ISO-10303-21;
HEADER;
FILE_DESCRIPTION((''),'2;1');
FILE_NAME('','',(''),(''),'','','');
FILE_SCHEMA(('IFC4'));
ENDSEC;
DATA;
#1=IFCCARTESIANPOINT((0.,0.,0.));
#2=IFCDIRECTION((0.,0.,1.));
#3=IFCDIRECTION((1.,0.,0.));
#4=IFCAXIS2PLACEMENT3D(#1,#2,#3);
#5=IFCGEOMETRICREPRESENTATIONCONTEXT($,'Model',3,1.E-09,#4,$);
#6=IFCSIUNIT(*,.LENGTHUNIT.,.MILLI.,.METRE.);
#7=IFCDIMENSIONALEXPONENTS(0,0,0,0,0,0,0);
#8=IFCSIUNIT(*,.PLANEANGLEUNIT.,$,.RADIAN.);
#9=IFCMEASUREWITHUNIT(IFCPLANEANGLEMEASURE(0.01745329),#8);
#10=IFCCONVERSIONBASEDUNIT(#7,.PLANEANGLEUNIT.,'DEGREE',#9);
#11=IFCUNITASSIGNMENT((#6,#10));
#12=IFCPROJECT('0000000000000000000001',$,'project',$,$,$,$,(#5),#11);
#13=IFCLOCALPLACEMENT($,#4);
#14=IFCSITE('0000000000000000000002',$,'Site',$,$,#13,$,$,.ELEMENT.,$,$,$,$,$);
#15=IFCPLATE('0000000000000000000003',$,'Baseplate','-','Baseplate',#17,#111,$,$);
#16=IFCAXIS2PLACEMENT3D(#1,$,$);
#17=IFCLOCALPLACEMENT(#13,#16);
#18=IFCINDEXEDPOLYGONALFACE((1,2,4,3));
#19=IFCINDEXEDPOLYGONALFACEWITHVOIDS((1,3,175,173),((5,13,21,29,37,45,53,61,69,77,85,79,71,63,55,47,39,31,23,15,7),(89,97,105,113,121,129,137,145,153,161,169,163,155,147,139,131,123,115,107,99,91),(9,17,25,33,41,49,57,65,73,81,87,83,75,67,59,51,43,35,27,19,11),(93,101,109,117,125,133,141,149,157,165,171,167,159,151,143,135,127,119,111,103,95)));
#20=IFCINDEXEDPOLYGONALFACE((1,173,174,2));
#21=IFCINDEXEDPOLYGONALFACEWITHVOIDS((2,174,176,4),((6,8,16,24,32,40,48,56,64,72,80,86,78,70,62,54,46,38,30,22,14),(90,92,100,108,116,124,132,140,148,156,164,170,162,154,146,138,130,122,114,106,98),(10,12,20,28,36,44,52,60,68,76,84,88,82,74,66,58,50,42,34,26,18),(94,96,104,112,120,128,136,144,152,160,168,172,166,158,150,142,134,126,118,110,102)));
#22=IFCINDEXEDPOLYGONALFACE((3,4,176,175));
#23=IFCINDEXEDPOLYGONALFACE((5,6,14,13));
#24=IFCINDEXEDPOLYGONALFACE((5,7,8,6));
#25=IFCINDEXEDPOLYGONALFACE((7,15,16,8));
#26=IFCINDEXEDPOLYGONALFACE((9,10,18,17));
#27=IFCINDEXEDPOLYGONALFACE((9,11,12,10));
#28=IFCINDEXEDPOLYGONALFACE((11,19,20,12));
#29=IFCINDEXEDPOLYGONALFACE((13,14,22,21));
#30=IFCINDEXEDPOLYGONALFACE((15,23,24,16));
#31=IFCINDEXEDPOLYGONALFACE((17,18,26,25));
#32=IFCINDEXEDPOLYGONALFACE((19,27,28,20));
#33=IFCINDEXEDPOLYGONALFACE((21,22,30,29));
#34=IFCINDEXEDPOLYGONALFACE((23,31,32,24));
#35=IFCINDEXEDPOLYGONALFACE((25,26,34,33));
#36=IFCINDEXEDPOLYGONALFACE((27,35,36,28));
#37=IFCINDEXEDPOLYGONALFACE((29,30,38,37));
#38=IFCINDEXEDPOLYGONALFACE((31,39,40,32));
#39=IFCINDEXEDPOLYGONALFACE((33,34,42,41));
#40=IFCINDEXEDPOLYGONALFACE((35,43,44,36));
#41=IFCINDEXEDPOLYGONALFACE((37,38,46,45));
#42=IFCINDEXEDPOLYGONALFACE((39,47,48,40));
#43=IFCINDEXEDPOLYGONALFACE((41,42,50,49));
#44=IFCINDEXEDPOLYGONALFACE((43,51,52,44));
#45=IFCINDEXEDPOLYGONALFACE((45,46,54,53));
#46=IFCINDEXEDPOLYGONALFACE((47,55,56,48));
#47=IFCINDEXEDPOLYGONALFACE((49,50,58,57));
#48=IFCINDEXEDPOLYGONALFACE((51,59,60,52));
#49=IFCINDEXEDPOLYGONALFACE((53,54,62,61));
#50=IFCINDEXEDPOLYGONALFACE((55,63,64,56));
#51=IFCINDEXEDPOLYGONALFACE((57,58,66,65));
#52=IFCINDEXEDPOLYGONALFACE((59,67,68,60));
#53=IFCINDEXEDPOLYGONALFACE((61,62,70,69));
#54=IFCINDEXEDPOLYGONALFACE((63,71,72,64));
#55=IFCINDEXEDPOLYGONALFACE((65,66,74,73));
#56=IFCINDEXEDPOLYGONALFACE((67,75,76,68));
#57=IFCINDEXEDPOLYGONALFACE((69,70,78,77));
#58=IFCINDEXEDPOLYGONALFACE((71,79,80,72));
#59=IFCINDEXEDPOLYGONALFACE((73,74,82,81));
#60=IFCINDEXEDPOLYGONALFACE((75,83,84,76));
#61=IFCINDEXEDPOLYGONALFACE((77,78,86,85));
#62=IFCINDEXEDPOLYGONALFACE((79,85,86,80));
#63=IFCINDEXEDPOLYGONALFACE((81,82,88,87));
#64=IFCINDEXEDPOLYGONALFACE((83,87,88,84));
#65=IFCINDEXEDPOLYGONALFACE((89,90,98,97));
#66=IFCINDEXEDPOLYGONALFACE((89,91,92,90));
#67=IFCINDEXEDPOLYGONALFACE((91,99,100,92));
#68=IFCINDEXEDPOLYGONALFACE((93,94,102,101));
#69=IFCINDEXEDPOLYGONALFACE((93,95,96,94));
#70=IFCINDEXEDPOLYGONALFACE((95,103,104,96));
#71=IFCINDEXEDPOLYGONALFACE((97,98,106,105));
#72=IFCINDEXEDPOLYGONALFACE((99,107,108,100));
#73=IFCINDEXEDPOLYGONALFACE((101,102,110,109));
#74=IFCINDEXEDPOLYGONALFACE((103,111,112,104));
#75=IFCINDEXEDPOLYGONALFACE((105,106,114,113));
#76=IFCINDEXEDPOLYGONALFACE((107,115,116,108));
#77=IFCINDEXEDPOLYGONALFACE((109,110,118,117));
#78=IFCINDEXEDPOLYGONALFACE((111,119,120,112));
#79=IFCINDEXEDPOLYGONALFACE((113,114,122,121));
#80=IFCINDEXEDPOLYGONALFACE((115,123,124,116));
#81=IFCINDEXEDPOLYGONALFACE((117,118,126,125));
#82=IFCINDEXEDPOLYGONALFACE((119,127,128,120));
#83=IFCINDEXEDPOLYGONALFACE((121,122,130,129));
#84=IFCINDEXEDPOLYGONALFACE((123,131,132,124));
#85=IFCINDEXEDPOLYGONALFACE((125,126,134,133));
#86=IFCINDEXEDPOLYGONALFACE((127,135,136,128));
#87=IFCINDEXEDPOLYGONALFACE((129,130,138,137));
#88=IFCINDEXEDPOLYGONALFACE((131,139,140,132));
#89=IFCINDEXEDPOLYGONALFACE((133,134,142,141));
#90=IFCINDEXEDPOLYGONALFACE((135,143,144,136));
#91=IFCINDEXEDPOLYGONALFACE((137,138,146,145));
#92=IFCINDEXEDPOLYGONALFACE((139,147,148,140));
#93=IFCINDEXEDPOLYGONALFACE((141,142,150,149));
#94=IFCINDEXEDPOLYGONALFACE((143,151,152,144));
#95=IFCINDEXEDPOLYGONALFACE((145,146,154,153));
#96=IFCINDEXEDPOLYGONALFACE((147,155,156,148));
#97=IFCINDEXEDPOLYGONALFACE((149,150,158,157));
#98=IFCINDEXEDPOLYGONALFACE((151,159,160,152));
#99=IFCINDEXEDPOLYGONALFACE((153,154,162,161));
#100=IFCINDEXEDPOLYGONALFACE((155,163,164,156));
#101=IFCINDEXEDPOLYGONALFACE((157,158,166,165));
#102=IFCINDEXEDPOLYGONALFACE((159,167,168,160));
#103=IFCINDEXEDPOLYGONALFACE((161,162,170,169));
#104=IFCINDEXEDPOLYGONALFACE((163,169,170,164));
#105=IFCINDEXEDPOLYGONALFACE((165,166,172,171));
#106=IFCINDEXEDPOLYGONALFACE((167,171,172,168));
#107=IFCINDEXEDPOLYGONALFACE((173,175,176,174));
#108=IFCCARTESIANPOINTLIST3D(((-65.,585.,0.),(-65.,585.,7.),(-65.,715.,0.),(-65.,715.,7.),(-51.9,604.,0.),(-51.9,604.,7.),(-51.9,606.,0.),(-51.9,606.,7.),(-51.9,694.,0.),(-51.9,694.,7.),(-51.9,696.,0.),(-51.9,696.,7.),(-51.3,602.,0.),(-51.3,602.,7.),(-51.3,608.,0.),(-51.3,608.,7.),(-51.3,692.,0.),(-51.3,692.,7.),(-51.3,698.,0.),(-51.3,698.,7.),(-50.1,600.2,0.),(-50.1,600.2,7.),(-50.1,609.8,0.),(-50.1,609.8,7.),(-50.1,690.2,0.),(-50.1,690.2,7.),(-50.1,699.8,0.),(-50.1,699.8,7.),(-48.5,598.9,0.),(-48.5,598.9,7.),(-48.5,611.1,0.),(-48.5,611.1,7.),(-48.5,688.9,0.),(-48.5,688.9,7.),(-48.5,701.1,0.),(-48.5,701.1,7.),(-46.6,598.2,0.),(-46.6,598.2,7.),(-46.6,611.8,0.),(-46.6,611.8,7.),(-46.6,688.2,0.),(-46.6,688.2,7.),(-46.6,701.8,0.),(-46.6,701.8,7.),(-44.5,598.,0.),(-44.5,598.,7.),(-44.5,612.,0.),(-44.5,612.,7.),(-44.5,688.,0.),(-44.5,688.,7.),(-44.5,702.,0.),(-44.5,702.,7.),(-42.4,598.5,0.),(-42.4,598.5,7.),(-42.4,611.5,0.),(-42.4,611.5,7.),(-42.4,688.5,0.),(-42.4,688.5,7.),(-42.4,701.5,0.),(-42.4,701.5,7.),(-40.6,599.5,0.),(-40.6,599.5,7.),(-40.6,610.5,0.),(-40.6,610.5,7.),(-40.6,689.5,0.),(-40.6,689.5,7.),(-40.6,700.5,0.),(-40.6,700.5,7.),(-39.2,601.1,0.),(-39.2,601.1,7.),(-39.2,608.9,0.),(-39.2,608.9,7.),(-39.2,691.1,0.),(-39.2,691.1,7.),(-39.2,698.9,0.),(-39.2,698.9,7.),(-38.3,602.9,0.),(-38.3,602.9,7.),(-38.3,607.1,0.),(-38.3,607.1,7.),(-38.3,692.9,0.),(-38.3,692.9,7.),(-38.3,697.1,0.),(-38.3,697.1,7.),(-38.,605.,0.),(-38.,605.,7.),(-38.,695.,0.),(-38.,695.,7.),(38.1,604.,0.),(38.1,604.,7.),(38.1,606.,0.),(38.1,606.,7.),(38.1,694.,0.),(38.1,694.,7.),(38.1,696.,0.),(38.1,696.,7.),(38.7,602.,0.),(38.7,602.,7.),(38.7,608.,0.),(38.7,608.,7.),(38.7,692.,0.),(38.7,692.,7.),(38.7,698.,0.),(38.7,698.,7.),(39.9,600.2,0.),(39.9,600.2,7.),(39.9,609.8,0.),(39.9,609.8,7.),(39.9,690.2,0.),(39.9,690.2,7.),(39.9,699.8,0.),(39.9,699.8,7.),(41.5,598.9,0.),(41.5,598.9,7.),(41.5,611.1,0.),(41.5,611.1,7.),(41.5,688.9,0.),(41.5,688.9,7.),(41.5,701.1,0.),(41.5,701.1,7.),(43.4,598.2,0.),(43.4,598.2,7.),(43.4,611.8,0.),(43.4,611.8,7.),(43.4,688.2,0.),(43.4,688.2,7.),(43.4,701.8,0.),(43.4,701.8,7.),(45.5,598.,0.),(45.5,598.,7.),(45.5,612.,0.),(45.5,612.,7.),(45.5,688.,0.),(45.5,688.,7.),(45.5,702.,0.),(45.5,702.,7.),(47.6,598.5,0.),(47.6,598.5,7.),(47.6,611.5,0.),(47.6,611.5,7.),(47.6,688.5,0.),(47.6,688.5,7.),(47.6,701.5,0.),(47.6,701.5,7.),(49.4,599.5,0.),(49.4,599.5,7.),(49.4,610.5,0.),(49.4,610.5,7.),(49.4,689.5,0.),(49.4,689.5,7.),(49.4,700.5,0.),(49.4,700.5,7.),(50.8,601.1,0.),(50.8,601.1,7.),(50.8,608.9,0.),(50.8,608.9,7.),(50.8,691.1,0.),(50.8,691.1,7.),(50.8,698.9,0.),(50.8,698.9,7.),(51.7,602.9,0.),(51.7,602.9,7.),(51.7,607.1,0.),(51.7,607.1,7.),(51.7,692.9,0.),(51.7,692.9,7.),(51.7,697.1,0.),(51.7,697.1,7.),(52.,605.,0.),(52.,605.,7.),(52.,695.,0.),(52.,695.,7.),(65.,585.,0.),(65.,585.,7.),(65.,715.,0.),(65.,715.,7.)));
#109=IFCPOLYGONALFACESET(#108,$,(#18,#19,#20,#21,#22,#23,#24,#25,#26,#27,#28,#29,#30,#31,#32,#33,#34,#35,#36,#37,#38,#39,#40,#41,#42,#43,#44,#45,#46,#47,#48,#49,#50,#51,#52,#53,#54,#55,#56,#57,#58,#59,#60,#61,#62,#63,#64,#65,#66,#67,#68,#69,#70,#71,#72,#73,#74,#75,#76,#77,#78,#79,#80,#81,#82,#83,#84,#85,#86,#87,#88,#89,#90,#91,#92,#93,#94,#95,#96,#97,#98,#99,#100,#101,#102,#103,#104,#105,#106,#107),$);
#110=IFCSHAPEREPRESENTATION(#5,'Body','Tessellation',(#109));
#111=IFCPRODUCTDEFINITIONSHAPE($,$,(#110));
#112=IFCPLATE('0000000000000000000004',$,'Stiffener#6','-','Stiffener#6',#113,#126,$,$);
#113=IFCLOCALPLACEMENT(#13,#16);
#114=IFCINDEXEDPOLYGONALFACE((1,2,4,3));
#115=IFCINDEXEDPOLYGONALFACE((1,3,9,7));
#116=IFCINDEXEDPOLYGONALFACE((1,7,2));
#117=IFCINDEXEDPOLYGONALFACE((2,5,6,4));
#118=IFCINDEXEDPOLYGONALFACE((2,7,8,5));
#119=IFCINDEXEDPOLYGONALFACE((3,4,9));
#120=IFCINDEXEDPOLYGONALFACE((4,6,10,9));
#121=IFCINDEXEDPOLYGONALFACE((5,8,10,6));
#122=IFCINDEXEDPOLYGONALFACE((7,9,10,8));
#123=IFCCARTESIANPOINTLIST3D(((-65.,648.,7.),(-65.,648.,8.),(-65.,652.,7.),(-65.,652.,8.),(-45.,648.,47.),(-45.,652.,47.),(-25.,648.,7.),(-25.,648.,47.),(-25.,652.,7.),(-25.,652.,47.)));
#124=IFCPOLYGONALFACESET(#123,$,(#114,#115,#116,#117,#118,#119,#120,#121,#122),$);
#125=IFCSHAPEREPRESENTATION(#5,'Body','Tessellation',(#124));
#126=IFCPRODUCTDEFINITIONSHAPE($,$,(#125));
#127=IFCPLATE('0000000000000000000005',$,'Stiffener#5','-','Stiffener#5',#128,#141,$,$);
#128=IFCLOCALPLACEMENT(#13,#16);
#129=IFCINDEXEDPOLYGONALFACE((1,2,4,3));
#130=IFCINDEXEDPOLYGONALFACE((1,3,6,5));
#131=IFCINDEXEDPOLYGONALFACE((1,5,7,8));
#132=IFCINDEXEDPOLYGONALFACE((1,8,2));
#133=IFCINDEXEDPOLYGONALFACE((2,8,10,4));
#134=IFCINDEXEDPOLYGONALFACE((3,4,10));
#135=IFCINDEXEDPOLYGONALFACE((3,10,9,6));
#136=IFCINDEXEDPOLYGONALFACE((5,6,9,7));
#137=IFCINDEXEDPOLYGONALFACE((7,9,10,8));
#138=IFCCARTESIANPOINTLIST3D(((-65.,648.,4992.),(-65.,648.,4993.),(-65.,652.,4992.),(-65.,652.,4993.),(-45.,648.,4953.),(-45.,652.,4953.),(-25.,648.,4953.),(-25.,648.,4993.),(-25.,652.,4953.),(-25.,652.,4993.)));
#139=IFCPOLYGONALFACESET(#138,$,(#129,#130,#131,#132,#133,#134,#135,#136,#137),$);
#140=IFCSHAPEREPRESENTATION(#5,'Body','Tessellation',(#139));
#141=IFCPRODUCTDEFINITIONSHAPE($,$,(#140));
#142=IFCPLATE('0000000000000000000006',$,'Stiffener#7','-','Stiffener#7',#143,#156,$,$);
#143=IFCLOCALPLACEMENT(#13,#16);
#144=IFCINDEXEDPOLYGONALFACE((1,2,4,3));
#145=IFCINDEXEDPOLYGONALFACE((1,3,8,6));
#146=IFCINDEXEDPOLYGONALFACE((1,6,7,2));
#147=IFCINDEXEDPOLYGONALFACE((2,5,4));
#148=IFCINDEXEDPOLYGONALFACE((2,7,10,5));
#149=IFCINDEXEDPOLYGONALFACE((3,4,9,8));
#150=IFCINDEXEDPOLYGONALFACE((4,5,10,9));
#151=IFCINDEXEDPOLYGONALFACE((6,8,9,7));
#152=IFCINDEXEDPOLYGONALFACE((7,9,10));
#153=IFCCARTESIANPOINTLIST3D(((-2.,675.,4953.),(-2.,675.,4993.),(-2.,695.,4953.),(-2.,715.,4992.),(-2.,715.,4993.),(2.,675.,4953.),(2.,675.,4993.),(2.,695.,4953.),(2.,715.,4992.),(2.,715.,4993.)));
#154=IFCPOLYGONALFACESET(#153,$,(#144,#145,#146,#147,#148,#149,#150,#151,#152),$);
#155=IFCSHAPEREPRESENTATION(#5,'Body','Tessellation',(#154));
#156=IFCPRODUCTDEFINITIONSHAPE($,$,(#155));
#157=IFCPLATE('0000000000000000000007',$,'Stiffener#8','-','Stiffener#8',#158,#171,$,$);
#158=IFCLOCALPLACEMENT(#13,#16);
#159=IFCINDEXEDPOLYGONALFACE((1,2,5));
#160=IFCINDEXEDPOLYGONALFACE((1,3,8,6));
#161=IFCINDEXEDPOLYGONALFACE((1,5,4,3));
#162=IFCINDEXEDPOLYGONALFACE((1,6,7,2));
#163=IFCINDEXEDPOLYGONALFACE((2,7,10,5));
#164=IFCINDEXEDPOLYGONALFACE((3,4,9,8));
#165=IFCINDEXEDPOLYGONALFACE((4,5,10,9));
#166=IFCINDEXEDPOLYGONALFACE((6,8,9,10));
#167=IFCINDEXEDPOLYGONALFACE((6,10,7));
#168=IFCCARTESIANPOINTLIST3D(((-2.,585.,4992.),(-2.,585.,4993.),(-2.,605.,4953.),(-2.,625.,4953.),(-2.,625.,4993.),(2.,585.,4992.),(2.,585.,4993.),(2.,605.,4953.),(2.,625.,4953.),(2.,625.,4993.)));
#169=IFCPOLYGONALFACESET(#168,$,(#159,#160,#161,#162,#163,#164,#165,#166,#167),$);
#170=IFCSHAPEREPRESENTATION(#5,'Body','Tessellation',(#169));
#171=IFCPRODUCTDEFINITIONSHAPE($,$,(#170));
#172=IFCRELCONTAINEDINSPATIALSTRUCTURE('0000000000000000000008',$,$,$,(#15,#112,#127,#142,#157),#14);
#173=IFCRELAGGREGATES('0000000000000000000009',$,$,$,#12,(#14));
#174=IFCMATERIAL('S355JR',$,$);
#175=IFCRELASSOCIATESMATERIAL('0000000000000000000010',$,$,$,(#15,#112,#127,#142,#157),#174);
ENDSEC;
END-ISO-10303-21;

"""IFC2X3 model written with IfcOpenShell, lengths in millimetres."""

from ifc_helpers import new_model, entity, si_unit, converted_unit, frame, frame_2d, origin, origin_with_axes, place, context, project, spatial, polyline, circle, outline, extrude, material, element, save


model = new_model("IFC2X3")

# Units and contexts
model_context = context("Model", 3, precision=1e-09, world=origin_with_axes())
ifc_project = project(units=[si_unit("LENGTHUNIT", "METRE", prefix="MILLI"), converted_unit("PLANEANGLEUNIT", "DEGREE", entity("IfcPlaneAngleMeasure", 0.01745329), si_unit("PLANEANGLEUNIT", "RADIAN"), dimensions=[0, 0, 0, 0, 0, 0, 0])], contexts=[model_context])

# Site
site_placement = place(None, origin_with_axes())
site = spatial("IfcSite", under=ifc_project, at=site_placement, Name="Site", CompositionType="ELEMENT")

# Shared definitions
ifc_material = material(Name="S355JR")

# Plate, openings
plate_1_placement = place(None, frame((-65.0, 715.0, 7.0), z_axis=(0.0, 0.0, -1.0), x_axis=(1.0, 0.0, 0.0)))
plate_1 = element("IfcPlate", 1, at=plate_1_placement, inside=site, material=ifc_material, Name="Baseplate", Description="-", ObjectType="Baseplate", context=model_context, shape_type="SweptSolid", body=[
    extrude(outline(polyline([(0.0, 0.0), (130.0, 0.0), (130.0, 130.0), (0.0, 130.0), (0.0, 0.0)])), origin_with_axes(), (0.0, 0.0, 1.0), 7.0),
])
opening_1_placement = place(plate_1_placement, frame((110.0, 65.0, 7.5), z_axis=(0.0, 0.0, -1.0), x_axis=(1.0, 0.0, 0.0)))
element("IfcOpeningElement", 2, at=opening_1_placement, cuts=plate_1, ObjectType="Opening", context=model_context, shape_type="SweptSolid", body=[
    extrude(circle(Radius=7.0, at=frame_2d((0.0, 45.0), x_axis=(1.0, 0.0))), origin(), (0.0, 0.0, 1.0), 8.0),
])
opening_2_placement = place(plate_1_placement, frame((110.0, 65.0, 7.5), z_axis=(0.0, 0.0, -1.0), x_axis=(1.0, 0.0, 0.0)))
element("IfcOpeningElement", 3, at=opening_2_placement, cuts=plate_1, ObjectType="Opening", context=model_context, shape_type="SweptSolid", body=[
    extrude(circle(Radius=7.0, at=frame_2d((0.0, -45.0), x_axis=(1.0, 0.0))), origin(), (0.0, 0.0, 1.0), 8.0),
])
opening_3_placement = place(plate_1_placement, frame((20.0, 65.0, 7.5), z_axis=(0.0, 0.0, -1.0), x_axis=(1.0, 0.0, 0.0)))
element("IfcOpeningElement", 4, at=opening_3_placement, cuts=plate_1, ObjectType="Opening", context=model_context, shape_type="SweptSolid", body=[
    extrude(circle(Radius=7.0, at=frame_2d((0.0, 45.0), x_axis=(1.0, 0.0))), origin(), (0.0, 0.0, 1.0), 8.0),
])
opening_4_placement = place(plate_1_placement, frame((20.0, 65.0, 7.5), z_axis=(0.0, 0.0, -1.0), x_axis=(1.0, 0.0, 0.0)))
element("IfcOpeningElement", 5, at=opening_4_placement, cuts=plate_1, ObjectType="Opening", context=model_context, shape_type="SweptSolid", body=[
    extrude(circle(Radius=7.0, at=frame_2d((0.0, -45.0), x_axis=(1.0, 0.0))), origin(), (0.0, 0.0, 1.0), 8.0),
])

# Plates, openings
plate_2_placement = place(None, frame((-25.0, 648.0, 7.0), z_axis=(0.0, 1.0, 0.0), x_axis=(-1.0, 0.0, 0.0)))
plate_2 = element("IfcPlate", 6, at=plate_2_placement, inside=site, material=ifc_material, Name="Stiffener#6", Description="-", ObjectType="Stiffener#6", context=model_context, shape_type="SweptSolid", body=[
    extrude(outline(polyline([(0.0, 0.0), (40.0, 0.0), (40.0, 40.0), (0.0, 40.0), (0.0, 0.0)])), origin_with_axes(), (0.0, 0.0, 1.0), 4.0),
])
opening_5_placement = place(plate_2_placement, frame((0.0, 0.0, 0.0), z_axis=(0.0, 0.0, 1.0), x_axis=(1.0, 0.0, 0.0)))
element("IfcOpeningElement", 7, at=opening_5_placement, cuts=plate_2, ObjectType="Opening", context=model_context, shape_type="SweptSolid", body=[
    extrude(outline(polyline([(40.0, 40.0), (20.0, 40.0), (40.0, 1.0), (40.0, 40.0)])), origin(), (0.0, 0.0, 1.0), 4.0),
])
plate_3_placement = place(None, frame((-25.0, 648.0, 4993.0), z_axis=(0.0, 1.0, 0.0), x_axis=(0.0, 0.0, -1.0)))
plate_3 = element("IfcPlate", 8, at=plate_3_placement, inside=site, material=ifc_material, Name="Stiffener#5", Description="-", ObjectType="Stiffener#5", context=model_context, shape_type="SweptSolid", body=[
    extrude(outline(polyline([(0.0, 0.0), (40.0, 0.0), (40.0, 40.0), (0.0, 40.0), (0.0, 0.0)])), origin_with_axes(), (0.0, 0.0, 1.0), 4.0),
])
opening_6_placement = place(plate_3_placement, frame((0.0, 0.0, 0.0), z_axis=(0.0, 0.0, 1.0), x_axis=(1.0, 0.0, 0.0)))
element("IfcOpeningElement", 9, at=opening_6_placement, cuts=plate_3, ObjectType="Opening", context=model_context, shape_type="SweptSolid", body=[
    extrude(outline(polyline([(40.0, 40.0), (1.0, 40.0), (40.0, 20.0), (40.0, 40.0)])), origin(), (0.0, 0.0, 1.0), 4.0),
])
plate_4_placement = place(None, frame((-2.0, 675.0, 4993.0), z_axis=(1.0, 0.0, 0.0), x_axis=(0.0, 0.0, -1.0)))
plate_4 = element("IfcPlate", 10, at=plate_4_placement, inside=site, material=ifc_material, Name="Stiffener#7", Description="-", ObjectType="Stiffener#7", context=model_context, shape_type="SweptSolid", body=[
    extrude(outline(polyline([(0.0, 0.0), (40.0, 0.0), (40.0, 40.0), (0.0, 40.0), (0.0, 0.0)])), origin_with_axes(), (0.0, 0.0, 1.0), 4.0),
])
opening_7_placement = place(plate_4_placement, frame((0.0, 0.0, 0.0), z_axis=(0.0, 0.0, 1.0), x_axis=(1.0, 0.0, 0.0)))
element("IfcOpeningElement", 11, at=opening_7_placement, cuts=plate_4, ObjectType="Opening", context=model_context, shape_type="SweptSolid", body=[
    extrude(outline(polyline([(40.0, 40.0), (1.0, 40.0), (40.0, 20.0), (40.0, 40.0)])), origin(), (0.0, 0.0, 1.0), 4.0),
])
plate_5_placement = place(None, frame((-2.0, 625.0, 4993.0), z_axis=(1.0, 0.0, 0.0), x_axis=(0.0, -1.0, 0.0)))
plate_5 = element("IfcPlate", 12, at=plate_5_placement, inside=site, material=ifc_material, Name="Stiffener#8", Description="-", ObjectType="Stiffener#8", context=model_context, shape_type="SweptSolid", body=[
    extrude(outline(polyline([(0.0, 0.0), (40.0, 0.0), (40.0, 40.0), (0.0, 40.0), (0.0, 0.0)])), origin_with_axes(), (0.0, 0.0, 1.0), 4.0),
])
opening_8_placement = place(plate_5_placement, frame((0.0, 0.0, 0.0), z_axis=(0.0, 0.0, 1.0), x_axis=(1.0, 0.0, 0.0)))
element("IfcOpeningElement", 13, at=opening_8_placement, cuts=plate_5, ObjectType="Opening", context=model_context, shape_type="SweptSolid", body=[
    extrude(outline(polyline([(40.0, 40.0), (20.0, 40.0), (40.0, 1.0), (40.0, 40.0)])), origin(), (0.0, 0.0, 1.0), 4.0),
])

save(model, "model.ifc")
